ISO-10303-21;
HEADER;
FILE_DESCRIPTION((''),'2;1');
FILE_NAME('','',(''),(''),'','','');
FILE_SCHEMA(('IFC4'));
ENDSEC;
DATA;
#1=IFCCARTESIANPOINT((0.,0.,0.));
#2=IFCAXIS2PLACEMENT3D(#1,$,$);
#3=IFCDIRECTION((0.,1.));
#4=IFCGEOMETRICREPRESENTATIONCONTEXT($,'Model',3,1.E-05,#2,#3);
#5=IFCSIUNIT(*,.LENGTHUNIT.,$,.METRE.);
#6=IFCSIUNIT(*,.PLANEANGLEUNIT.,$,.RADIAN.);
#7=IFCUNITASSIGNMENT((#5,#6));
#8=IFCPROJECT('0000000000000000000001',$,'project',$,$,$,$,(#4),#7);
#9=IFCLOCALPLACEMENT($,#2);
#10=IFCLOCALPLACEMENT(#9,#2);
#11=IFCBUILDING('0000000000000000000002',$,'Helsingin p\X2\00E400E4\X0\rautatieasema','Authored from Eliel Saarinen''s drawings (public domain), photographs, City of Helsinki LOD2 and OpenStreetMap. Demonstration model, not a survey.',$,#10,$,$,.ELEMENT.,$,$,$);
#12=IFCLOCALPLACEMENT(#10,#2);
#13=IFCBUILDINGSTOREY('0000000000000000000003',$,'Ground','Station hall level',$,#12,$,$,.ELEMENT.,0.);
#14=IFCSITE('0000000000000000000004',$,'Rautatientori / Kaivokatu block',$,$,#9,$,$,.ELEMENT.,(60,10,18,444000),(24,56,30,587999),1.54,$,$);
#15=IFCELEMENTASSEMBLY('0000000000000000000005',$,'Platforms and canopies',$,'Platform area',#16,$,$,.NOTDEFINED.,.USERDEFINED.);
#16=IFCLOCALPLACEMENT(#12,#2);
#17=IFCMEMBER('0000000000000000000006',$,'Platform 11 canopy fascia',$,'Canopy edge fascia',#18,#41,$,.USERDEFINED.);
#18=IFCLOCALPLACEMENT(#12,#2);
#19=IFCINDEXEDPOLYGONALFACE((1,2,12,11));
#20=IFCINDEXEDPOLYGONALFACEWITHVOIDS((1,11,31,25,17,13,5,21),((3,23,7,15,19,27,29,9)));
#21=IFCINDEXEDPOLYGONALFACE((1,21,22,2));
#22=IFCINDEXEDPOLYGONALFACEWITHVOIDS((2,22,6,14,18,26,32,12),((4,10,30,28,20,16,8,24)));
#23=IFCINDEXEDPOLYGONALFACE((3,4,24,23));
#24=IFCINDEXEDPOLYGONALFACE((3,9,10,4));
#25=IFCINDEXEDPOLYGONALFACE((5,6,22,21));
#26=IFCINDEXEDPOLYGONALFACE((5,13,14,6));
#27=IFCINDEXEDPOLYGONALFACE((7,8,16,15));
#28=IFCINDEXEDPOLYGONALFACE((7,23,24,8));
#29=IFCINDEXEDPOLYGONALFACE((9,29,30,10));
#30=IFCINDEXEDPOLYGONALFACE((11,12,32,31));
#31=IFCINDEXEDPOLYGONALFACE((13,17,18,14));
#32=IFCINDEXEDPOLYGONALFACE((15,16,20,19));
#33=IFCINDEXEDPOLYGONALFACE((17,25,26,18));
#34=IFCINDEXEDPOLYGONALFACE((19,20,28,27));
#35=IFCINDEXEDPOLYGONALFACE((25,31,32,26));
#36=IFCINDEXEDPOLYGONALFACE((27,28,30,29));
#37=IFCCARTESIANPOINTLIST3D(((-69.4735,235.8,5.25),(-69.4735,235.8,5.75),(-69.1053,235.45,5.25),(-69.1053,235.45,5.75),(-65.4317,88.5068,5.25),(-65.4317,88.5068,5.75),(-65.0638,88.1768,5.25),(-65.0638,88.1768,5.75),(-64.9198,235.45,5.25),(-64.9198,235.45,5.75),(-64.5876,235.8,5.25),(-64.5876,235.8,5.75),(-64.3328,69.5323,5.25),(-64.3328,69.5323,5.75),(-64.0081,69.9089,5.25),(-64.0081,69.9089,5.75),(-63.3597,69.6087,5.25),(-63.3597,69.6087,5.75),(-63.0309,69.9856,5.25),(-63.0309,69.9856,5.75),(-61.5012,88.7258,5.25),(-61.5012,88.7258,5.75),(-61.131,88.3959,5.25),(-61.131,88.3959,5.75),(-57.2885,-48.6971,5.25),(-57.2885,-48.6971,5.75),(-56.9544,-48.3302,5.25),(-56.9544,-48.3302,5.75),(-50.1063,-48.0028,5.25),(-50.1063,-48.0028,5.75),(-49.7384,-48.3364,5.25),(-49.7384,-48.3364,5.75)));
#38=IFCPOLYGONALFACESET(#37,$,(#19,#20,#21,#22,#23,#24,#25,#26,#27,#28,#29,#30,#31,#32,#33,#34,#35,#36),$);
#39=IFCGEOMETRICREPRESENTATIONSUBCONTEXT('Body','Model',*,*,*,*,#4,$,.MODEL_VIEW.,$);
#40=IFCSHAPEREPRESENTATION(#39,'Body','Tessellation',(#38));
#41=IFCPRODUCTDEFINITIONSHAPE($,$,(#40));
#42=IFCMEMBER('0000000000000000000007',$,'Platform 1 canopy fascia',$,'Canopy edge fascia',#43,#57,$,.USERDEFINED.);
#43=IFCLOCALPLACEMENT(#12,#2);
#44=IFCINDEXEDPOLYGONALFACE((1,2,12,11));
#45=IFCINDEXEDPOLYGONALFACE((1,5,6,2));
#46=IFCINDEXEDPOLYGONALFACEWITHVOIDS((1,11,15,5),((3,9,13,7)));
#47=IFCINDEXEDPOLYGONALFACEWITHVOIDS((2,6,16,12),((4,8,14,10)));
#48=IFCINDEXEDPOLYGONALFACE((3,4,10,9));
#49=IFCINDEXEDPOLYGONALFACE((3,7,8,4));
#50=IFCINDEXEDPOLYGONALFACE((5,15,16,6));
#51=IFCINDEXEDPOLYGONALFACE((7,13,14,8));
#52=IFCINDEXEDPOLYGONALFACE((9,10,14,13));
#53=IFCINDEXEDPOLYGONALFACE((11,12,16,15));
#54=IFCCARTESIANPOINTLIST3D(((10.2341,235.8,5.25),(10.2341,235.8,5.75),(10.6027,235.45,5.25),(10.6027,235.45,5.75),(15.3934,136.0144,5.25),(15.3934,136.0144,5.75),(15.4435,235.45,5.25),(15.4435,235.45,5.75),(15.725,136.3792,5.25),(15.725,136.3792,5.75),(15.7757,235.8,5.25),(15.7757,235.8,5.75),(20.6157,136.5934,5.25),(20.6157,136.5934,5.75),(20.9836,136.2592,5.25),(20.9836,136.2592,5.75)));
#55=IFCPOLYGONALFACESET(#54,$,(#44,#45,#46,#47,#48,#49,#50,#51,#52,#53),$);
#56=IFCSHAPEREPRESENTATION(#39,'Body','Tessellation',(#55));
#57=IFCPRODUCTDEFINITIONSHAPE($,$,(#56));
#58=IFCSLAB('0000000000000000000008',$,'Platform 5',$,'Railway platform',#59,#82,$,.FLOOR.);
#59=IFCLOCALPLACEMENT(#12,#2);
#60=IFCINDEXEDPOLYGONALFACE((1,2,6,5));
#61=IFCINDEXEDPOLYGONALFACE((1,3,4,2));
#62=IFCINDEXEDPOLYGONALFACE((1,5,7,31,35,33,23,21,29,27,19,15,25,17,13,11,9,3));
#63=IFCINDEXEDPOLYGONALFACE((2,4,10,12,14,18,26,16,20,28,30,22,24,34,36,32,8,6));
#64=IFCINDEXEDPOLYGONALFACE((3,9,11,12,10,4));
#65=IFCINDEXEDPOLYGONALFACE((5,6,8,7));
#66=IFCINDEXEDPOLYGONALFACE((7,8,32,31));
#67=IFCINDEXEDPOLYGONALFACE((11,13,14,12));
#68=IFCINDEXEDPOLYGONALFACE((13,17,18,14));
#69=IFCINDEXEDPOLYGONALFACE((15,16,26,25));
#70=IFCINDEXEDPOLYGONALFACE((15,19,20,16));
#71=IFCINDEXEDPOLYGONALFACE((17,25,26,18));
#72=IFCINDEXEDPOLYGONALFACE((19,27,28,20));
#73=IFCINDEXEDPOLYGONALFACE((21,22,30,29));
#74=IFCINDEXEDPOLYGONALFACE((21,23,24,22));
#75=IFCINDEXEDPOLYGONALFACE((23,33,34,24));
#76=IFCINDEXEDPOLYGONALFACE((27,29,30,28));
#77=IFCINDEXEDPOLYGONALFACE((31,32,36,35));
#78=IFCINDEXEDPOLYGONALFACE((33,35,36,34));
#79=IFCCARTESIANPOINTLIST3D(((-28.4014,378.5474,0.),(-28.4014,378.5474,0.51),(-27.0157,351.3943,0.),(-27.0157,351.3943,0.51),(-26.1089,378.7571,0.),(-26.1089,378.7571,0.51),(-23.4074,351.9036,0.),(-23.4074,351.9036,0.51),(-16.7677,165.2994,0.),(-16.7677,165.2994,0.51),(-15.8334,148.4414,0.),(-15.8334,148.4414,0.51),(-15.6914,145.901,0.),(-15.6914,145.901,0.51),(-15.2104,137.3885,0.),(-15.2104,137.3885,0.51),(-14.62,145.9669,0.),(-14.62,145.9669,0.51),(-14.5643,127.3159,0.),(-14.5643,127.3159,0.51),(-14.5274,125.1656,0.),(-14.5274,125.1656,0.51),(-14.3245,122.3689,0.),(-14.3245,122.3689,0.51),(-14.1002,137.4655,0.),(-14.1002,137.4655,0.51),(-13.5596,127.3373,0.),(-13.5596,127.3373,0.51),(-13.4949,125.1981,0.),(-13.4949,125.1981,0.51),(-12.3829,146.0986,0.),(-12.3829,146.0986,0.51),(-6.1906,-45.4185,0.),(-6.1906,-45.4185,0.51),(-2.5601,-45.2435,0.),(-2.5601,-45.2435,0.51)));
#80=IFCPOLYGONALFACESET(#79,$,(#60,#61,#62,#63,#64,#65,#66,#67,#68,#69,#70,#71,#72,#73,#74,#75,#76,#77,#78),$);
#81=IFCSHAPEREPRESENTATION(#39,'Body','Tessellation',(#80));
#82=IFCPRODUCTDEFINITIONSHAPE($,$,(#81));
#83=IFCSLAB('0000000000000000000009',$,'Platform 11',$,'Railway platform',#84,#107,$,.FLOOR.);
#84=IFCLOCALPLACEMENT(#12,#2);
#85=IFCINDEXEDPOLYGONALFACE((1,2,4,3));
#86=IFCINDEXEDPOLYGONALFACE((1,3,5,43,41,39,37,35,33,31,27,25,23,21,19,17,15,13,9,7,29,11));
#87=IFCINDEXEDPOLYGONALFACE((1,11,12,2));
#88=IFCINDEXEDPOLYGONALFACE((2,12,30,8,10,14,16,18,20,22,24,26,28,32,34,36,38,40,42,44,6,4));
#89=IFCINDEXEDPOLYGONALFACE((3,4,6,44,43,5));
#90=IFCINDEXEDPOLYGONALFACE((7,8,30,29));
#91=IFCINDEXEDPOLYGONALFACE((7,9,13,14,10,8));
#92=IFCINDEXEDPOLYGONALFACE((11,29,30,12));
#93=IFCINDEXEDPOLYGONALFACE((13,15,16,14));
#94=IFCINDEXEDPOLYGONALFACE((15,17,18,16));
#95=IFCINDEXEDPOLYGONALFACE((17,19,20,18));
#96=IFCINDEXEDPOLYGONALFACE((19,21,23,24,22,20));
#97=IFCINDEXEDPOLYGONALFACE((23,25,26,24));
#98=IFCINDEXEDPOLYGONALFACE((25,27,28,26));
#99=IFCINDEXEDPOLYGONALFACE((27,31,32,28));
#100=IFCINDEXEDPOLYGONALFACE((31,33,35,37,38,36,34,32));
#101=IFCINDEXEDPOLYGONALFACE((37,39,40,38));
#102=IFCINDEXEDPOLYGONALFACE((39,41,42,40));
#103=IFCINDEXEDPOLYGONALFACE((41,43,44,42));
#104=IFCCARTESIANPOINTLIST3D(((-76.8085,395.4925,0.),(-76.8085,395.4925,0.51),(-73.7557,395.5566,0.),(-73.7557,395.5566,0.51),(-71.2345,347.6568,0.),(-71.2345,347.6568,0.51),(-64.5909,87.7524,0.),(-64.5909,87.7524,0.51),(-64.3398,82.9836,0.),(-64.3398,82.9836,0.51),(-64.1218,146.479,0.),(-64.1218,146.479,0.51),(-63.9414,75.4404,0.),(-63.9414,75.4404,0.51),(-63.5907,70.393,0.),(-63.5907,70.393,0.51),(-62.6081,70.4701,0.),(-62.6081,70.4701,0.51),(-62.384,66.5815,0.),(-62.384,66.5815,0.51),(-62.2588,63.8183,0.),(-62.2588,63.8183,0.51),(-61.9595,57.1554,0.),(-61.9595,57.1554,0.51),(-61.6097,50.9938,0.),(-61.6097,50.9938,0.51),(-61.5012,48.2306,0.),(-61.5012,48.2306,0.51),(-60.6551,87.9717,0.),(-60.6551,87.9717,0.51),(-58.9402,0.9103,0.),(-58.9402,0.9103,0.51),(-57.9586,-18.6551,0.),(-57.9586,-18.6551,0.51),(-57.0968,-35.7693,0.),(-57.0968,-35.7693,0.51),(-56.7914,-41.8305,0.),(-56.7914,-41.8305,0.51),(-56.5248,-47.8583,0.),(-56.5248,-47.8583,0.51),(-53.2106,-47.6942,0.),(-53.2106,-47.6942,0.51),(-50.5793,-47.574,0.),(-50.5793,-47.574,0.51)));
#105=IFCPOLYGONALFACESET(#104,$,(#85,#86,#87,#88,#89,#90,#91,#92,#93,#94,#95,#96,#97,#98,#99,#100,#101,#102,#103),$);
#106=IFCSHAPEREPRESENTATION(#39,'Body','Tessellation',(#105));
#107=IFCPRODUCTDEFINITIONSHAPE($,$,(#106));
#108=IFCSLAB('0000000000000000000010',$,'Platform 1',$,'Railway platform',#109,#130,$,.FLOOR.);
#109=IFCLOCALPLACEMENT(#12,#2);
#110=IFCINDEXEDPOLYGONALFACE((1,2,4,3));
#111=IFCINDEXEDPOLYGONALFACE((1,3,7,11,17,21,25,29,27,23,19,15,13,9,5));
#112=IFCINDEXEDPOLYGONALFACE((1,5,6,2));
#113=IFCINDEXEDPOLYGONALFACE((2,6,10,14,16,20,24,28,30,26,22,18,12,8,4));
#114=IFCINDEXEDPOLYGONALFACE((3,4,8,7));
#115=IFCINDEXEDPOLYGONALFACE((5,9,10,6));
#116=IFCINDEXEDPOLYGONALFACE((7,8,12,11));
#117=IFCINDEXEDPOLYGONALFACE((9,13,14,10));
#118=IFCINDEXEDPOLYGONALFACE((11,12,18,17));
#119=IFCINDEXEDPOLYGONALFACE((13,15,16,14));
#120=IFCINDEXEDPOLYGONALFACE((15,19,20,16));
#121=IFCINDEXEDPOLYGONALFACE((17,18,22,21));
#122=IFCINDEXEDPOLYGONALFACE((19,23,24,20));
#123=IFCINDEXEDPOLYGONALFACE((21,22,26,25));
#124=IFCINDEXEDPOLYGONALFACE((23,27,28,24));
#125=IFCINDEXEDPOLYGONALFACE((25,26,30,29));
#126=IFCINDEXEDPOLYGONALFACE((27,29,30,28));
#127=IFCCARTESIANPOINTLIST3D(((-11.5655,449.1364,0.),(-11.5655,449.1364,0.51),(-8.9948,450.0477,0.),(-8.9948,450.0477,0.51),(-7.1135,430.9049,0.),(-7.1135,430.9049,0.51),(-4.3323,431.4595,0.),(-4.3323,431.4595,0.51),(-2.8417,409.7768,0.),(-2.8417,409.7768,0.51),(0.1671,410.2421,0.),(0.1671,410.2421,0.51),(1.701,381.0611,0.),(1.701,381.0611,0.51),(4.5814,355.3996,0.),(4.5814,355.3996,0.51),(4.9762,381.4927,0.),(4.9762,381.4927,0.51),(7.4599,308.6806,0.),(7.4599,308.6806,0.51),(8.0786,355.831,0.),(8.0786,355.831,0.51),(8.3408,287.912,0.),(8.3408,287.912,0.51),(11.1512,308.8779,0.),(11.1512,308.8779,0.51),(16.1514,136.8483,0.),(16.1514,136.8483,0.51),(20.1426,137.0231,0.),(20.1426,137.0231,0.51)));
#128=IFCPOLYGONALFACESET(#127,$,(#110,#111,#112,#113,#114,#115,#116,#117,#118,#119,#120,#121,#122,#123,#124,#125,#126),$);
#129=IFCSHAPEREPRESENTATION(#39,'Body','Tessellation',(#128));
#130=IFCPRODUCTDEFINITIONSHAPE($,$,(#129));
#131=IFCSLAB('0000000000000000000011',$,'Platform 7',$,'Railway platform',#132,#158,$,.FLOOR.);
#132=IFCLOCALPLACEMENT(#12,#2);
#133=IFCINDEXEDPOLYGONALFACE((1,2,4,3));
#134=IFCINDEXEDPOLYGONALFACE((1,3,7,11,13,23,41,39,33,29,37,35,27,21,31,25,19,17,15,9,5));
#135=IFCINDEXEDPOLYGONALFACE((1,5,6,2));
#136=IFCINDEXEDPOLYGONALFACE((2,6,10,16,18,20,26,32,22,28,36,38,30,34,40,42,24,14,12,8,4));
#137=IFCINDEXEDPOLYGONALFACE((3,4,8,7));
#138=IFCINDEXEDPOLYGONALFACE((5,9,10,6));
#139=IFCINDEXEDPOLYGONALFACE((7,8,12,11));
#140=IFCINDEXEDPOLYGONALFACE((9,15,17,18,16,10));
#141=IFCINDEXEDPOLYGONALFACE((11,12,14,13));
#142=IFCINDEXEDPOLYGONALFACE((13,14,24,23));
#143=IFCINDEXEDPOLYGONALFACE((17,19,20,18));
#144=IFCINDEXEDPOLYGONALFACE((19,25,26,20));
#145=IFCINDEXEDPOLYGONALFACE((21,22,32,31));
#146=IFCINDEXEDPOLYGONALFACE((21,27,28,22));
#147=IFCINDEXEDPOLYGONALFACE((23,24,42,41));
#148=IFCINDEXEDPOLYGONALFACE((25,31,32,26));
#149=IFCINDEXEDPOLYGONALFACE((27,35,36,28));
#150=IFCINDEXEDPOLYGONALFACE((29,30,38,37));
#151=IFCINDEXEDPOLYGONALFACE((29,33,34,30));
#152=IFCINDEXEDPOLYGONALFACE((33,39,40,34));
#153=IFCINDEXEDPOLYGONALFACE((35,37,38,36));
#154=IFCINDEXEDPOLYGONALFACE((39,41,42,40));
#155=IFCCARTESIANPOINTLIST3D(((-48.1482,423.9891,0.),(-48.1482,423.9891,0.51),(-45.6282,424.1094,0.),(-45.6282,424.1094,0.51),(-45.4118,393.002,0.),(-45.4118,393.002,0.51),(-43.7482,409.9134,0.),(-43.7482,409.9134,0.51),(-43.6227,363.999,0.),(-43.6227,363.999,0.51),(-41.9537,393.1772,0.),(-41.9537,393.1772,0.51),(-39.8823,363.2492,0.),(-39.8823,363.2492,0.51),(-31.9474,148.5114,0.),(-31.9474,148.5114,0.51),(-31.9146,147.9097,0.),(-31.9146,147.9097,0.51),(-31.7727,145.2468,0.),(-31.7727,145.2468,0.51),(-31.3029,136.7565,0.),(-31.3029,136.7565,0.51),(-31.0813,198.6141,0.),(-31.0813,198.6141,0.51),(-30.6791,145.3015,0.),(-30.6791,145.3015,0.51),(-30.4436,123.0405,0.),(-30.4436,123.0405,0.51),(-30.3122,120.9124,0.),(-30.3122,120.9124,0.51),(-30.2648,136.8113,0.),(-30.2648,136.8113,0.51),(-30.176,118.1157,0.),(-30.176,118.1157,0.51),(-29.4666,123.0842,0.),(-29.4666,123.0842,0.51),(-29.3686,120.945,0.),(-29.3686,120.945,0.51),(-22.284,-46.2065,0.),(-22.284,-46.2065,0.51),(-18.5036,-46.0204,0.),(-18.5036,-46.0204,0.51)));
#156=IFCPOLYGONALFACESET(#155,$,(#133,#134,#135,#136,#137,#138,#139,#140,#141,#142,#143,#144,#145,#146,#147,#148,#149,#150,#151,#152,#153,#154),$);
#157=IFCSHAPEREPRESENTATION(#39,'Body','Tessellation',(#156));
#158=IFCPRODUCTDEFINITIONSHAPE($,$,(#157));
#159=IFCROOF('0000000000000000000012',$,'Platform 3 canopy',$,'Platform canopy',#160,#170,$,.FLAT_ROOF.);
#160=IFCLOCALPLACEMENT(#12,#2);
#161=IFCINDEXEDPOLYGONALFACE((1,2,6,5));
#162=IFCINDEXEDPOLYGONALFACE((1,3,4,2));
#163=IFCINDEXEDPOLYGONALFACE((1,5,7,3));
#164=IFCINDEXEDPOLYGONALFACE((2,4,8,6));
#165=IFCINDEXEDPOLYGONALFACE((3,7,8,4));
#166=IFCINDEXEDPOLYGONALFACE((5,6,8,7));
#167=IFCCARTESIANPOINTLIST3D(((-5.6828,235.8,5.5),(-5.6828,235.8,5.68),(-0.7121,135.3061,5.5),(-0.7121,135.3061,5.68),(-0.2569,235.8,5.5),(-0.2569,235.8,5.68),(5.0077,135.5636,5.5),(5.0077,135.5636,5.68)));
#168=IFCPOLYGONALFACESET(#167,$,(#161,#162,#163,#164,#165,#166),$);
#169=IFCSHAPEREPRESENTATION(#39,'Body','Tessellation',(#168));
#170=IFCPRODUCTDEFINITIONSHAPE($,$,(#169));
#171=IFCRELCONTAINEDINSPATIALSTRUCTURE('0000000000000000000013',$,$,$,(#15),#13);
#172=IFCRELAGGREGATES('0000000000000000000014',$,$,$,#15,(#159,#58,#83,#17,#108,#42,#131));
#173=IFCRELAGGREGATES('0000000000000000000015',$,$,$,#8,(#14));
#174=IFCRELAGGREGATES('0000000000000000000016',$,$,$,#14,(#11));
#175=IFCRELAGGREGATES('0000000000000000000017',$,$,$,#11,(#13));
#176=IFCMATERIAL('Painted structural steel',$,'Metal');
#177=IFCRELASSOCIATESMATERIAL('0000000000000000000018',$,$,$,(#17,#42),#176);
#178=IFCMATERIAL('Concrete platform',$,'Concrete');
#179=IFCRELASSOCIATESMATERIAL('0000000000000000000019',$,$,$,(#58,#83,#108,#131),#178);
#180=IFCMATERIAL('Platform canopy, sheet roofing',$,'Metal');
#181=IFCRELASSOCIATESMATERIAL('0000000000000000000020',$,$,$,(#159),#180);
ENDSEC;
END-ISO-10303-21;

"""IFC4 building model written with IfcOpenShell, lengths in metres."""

from ifc_helpers import new_model, si_unit, direction, frame, origin, place, context, subcontext, project, spatial, polyline, outline, extrude, material, element, aggregate, save


model = new_model("IFC4")

# Units and contexts
model_context = context("Model", 3, precision=1e-05, world=origin(), true_north=direction((0.0, 1.0)))
body_context = subcontext(model_context, "Body", "Model", "MODEL_VIEW")
ifc_project = project(units=[si_unit("LENGTHUNIT", "METRE"), si_unit("PLANEANGLEUNIT", "RADIAN")], contexts=[model_context])

# Site, building, storey
site_placement = place(None, origin())
site = spatial("IfcSite", under=ifc_project, at=site_placement, Name="Rautatientori / Kaivokatu block", CompositionType="ELEMENT", RefLatitude=(60, 10, 18, 444000), RefLongitude=(24, 56, 30, 587999), RefElevation=1.54)
building_placement = place(site_placement, origin())
building = spatial("IfcBuilding", under=site, at=building_placement, Name="Helsingin päärautatieasema", Description="Authored from Eliel Saarinen's drawings (public domain), photographs, City of Helsinki LOD2 and OpenStreetMap. Demonstration model, not a survey.", CompositionType="ELEMENT")
storey_placement = place(building_placement, origin())
storey = spatial("IfcBuildingStorey", under=building, at=storey_placement, Name="Ground", Description="Station hall level", CompositionType="ELEMENT", Elevation=0.0)

# Element assembly, members, slabs, roof
assembly_placement = place(building_placement, origin())
assembly = element("IfcElementAssembly", 1, at=assembly_placement, inside=storey, Name="Platforms and canopies", ObjectType="Platform area", AssemblyPlace="NOTDEFINED", PredefinedType="USERDEFINED")
ifc_material_1 = material(Name="Painted structural steel", Category="Metal")
member_1_placement = place(building_placement, origin())
member_1 = element("IfcMember", 2, at=member_1_placement, material=ifc_material_1, Name="Platform 11 canopy fascia", ObjectType="Canopy edge fascia", PredefinedType="USERDEFINED", context=body_context, shape_type="SweptSolid", body=[
    extrude(outline(polyline([(-49.7384, -48.3364), (-57.2885, -48.6971), (-63.3597, 69.6087), (-64.3328, 69.5323), (-65.4317, 88.5068), (-61.5012, 88.7258), (-69.4735, 235.8), (-64.5876, 235.8), (-49.7384, -48.3364)]), holes=[polyline([(-50.1063, -48.0028), (-56.9544, -48.3302), (-63.0309, 69.9856), (-64.0081, 69.9089), (-65.0638, 88.1768), (-61.131, 88.3959), (-69.1053, 235.45), (-64.9198, 235.45), (-50.1063, -48.0028)])]), frame((0.0, 0.0, 5.25)), (0.0, 0.0, 1.0), 0.5),
])
member_2_placement = place(building_placement, origin())
member_2 = element("IfcMember", 3, at=member_2_placement, material=ifc_material_1, Name="Platform 1 canopy fascia", ObjectType="Canopy edge fascia", PredefinedType="USERDEFINED", context=body_context, shape_type="SweptSolid", body=[
    extrude(outline(polyline([(15.3934, 136.0144), (10.2341, 235.8), (15.7757, 235.8), (20.9836, 136.2592), (15.3934, 136.0144)]), holes=[polyline([(15.725, 136.3792), (10.6027, 235.45), (15.4435, 235.45), (20.6157, 136.5934), (15.725, 136.3792)])]), frame((0.0, 0.0, 5.25)), (0.0, 0.0, 1.0), 0.5),
])
ifc_material_2 = material(Name="Concrete platform", Category="Concrete")
slab_1_placement = place(building_placement, origin())
slab_1 = element("IfcSlab", 4, at=slab_1_placement, material=ifc_material_2, Name="Platform 5", ObjectType="Railway platform", PredefinedType="FLOOR", context=body_context, shape_type="SweptSolid", body=[
    extrude(outline(polyline([(-14.62, 145.9669), (-15.6914, 145.901), (-15.8334, 148.4414), (-16.7677, 165.2994), (-27.0157, 351.3943), (-28.4014, 378.5474), (-26.1089, 378.7571), (-23.4074, 351.9036), (-12.3829, 146.0986), (-2.5601, -45.2435), (-6.1906, -45.4185), (-14.3245, 122.3689), (-14.5274, 125.1656), (-13.4949, 125.1981), (-13.5596, 127.3373), (-14.5643, 127.3159), (-15.2104, 137.3885), (-14.1002, 137.4655), (-14.62, 145.9669)])), origin(), (0.0, 0.0, 1.0), 0.51),
])
slab_2_placement = place(building_placement, origin())
slab_2 = element("IfcSlab", 5, at=slab_2_placement, material=ifc_material_2, Name="Platform 11", ObjectType="Railway platform", PredefinedType="FLOOR", context=body_context, shape_type="SweptSolid", body=[
    extrude(outline(polyline([(-76.8085, 395.4925), (-73.7557, 395.5566), (-71.2345, 347.6568), (-50.5793, -47.574), (-53.2106, -47.6942), (-56.5248, -47.8583), (-56.7914, -41.8305), (-57.0968, -35.7693), (-57.9586, -18.6551), (-58.9402, 0.9103), (-61.5012, 48.2306), (-61.6097, 50.9938), (-61.9595, 57.1554), (-62.2588, 63.8183), (-62.384, 66.5815), (-62.6081, 70.4701), (-63.5907, 70.393), (-63.9414, 75.4404), (-64.3398, 82.9836), (-64.5909, 87.7524), (-60.6551, 87.9717), (-64.1218, 146.479), (-76.8085, 395.4925)])), origin(), (0.0, 0.0, 1.0), 0.51),
])
slab_3_placement = place(building_placement, origin())
slab_3 = element("IfcSlab", 6, at=slab_3_placement, material=ifc_material_2, Name="Platform 1", ObjectType="Railway platform", PredefinedType="FLOOR", context=body_context, shape_type="SweptSolid", body=[
    extrude(outline(polyline([(20.1426, 137.0231), (16.1514, 136.8483), (8.3408, 287.912), (7.4599, 308.6806), (4.5814, 355.3996), (1.701, 381.0611), (-2.8417, 409.7768), (-7.1135, 430.9049), (-11.5655, 449.1364), (-8.9948, 450.0477), (-4.3323, 431.4595), (0.1671, 410.2421), (4.9762, 381.4927), (8.0786, 355.831), (11.1512, 308.8779), (20.1426, 137.0231)])), origin(), (0.0, 0.0, 1.0), 0.51),
])
slab_4_placement = place(building_placement, origin())
slab_4 = element("IfcSlab", 7, at=slab_4_placement, material=ifc_material_2, Name="Platform 7", ObjectType="Railway platform", PredefinedType="FLOOR", context=body_context, shape_type="SweptSolid", body=[
    extrude(outline(polyline([(-18.5036, -46.0204), (-22.284, -46.2065), (-30.176, 118.1157), (-30.3122, 120.9124), (-29.3686, 120.945), (-29.4666, 123.0842), (-30.4436, 123.0405), (-31.3029, 136.7565), (-30.2648, 136.8113), (-30.6791, 145.3015), (-31.7727, 145.2468), (-31.9146, 147.9097), (-31.9474, 148.5114), (-43.6227, 363.999), (-45.4118, 393.002), (-48.1482, 423.9891), (-45.6282, 424.1094), (-43.7482, 409.9134), (-41.9537, 393.1772), (-39.8823, 363.2492), (-31.0813, 198.6141), (-18.5036, -46.0204)])), origin(), (0.0, 0.0, 1.0), 0.51),
])
ifc_material_3 = material(Name="Platform canopy, sheet roofing", Category="Metal")
roof_1_placement = place(building_placement, origin())
roof_1 = element("IfcRoof", 8, at=roof_1_placement, material=ifc_material_3, Name="Platform 3 canopy", ObjectType="Platform canopy", PredefinedType="FLAT_ROOF", context=body_context, shape_type="SweptSolid", body=[
    extrude(outline(polyline([(-5.6828, 235.8), (-0.2569, 235.8), (5.0077, 135.5636), (-0.7121, 135.3061), (-5.6828, 235.8)])), frame((0.0, 0.0, 5.5)), (0.0, 0.0, 1.0), 0.18),
])
aggregate(assembly, [roof_1, slab_1, slab_2, member_1, slab_3, member_2, slab_4])

save(model, "model.ifc")
